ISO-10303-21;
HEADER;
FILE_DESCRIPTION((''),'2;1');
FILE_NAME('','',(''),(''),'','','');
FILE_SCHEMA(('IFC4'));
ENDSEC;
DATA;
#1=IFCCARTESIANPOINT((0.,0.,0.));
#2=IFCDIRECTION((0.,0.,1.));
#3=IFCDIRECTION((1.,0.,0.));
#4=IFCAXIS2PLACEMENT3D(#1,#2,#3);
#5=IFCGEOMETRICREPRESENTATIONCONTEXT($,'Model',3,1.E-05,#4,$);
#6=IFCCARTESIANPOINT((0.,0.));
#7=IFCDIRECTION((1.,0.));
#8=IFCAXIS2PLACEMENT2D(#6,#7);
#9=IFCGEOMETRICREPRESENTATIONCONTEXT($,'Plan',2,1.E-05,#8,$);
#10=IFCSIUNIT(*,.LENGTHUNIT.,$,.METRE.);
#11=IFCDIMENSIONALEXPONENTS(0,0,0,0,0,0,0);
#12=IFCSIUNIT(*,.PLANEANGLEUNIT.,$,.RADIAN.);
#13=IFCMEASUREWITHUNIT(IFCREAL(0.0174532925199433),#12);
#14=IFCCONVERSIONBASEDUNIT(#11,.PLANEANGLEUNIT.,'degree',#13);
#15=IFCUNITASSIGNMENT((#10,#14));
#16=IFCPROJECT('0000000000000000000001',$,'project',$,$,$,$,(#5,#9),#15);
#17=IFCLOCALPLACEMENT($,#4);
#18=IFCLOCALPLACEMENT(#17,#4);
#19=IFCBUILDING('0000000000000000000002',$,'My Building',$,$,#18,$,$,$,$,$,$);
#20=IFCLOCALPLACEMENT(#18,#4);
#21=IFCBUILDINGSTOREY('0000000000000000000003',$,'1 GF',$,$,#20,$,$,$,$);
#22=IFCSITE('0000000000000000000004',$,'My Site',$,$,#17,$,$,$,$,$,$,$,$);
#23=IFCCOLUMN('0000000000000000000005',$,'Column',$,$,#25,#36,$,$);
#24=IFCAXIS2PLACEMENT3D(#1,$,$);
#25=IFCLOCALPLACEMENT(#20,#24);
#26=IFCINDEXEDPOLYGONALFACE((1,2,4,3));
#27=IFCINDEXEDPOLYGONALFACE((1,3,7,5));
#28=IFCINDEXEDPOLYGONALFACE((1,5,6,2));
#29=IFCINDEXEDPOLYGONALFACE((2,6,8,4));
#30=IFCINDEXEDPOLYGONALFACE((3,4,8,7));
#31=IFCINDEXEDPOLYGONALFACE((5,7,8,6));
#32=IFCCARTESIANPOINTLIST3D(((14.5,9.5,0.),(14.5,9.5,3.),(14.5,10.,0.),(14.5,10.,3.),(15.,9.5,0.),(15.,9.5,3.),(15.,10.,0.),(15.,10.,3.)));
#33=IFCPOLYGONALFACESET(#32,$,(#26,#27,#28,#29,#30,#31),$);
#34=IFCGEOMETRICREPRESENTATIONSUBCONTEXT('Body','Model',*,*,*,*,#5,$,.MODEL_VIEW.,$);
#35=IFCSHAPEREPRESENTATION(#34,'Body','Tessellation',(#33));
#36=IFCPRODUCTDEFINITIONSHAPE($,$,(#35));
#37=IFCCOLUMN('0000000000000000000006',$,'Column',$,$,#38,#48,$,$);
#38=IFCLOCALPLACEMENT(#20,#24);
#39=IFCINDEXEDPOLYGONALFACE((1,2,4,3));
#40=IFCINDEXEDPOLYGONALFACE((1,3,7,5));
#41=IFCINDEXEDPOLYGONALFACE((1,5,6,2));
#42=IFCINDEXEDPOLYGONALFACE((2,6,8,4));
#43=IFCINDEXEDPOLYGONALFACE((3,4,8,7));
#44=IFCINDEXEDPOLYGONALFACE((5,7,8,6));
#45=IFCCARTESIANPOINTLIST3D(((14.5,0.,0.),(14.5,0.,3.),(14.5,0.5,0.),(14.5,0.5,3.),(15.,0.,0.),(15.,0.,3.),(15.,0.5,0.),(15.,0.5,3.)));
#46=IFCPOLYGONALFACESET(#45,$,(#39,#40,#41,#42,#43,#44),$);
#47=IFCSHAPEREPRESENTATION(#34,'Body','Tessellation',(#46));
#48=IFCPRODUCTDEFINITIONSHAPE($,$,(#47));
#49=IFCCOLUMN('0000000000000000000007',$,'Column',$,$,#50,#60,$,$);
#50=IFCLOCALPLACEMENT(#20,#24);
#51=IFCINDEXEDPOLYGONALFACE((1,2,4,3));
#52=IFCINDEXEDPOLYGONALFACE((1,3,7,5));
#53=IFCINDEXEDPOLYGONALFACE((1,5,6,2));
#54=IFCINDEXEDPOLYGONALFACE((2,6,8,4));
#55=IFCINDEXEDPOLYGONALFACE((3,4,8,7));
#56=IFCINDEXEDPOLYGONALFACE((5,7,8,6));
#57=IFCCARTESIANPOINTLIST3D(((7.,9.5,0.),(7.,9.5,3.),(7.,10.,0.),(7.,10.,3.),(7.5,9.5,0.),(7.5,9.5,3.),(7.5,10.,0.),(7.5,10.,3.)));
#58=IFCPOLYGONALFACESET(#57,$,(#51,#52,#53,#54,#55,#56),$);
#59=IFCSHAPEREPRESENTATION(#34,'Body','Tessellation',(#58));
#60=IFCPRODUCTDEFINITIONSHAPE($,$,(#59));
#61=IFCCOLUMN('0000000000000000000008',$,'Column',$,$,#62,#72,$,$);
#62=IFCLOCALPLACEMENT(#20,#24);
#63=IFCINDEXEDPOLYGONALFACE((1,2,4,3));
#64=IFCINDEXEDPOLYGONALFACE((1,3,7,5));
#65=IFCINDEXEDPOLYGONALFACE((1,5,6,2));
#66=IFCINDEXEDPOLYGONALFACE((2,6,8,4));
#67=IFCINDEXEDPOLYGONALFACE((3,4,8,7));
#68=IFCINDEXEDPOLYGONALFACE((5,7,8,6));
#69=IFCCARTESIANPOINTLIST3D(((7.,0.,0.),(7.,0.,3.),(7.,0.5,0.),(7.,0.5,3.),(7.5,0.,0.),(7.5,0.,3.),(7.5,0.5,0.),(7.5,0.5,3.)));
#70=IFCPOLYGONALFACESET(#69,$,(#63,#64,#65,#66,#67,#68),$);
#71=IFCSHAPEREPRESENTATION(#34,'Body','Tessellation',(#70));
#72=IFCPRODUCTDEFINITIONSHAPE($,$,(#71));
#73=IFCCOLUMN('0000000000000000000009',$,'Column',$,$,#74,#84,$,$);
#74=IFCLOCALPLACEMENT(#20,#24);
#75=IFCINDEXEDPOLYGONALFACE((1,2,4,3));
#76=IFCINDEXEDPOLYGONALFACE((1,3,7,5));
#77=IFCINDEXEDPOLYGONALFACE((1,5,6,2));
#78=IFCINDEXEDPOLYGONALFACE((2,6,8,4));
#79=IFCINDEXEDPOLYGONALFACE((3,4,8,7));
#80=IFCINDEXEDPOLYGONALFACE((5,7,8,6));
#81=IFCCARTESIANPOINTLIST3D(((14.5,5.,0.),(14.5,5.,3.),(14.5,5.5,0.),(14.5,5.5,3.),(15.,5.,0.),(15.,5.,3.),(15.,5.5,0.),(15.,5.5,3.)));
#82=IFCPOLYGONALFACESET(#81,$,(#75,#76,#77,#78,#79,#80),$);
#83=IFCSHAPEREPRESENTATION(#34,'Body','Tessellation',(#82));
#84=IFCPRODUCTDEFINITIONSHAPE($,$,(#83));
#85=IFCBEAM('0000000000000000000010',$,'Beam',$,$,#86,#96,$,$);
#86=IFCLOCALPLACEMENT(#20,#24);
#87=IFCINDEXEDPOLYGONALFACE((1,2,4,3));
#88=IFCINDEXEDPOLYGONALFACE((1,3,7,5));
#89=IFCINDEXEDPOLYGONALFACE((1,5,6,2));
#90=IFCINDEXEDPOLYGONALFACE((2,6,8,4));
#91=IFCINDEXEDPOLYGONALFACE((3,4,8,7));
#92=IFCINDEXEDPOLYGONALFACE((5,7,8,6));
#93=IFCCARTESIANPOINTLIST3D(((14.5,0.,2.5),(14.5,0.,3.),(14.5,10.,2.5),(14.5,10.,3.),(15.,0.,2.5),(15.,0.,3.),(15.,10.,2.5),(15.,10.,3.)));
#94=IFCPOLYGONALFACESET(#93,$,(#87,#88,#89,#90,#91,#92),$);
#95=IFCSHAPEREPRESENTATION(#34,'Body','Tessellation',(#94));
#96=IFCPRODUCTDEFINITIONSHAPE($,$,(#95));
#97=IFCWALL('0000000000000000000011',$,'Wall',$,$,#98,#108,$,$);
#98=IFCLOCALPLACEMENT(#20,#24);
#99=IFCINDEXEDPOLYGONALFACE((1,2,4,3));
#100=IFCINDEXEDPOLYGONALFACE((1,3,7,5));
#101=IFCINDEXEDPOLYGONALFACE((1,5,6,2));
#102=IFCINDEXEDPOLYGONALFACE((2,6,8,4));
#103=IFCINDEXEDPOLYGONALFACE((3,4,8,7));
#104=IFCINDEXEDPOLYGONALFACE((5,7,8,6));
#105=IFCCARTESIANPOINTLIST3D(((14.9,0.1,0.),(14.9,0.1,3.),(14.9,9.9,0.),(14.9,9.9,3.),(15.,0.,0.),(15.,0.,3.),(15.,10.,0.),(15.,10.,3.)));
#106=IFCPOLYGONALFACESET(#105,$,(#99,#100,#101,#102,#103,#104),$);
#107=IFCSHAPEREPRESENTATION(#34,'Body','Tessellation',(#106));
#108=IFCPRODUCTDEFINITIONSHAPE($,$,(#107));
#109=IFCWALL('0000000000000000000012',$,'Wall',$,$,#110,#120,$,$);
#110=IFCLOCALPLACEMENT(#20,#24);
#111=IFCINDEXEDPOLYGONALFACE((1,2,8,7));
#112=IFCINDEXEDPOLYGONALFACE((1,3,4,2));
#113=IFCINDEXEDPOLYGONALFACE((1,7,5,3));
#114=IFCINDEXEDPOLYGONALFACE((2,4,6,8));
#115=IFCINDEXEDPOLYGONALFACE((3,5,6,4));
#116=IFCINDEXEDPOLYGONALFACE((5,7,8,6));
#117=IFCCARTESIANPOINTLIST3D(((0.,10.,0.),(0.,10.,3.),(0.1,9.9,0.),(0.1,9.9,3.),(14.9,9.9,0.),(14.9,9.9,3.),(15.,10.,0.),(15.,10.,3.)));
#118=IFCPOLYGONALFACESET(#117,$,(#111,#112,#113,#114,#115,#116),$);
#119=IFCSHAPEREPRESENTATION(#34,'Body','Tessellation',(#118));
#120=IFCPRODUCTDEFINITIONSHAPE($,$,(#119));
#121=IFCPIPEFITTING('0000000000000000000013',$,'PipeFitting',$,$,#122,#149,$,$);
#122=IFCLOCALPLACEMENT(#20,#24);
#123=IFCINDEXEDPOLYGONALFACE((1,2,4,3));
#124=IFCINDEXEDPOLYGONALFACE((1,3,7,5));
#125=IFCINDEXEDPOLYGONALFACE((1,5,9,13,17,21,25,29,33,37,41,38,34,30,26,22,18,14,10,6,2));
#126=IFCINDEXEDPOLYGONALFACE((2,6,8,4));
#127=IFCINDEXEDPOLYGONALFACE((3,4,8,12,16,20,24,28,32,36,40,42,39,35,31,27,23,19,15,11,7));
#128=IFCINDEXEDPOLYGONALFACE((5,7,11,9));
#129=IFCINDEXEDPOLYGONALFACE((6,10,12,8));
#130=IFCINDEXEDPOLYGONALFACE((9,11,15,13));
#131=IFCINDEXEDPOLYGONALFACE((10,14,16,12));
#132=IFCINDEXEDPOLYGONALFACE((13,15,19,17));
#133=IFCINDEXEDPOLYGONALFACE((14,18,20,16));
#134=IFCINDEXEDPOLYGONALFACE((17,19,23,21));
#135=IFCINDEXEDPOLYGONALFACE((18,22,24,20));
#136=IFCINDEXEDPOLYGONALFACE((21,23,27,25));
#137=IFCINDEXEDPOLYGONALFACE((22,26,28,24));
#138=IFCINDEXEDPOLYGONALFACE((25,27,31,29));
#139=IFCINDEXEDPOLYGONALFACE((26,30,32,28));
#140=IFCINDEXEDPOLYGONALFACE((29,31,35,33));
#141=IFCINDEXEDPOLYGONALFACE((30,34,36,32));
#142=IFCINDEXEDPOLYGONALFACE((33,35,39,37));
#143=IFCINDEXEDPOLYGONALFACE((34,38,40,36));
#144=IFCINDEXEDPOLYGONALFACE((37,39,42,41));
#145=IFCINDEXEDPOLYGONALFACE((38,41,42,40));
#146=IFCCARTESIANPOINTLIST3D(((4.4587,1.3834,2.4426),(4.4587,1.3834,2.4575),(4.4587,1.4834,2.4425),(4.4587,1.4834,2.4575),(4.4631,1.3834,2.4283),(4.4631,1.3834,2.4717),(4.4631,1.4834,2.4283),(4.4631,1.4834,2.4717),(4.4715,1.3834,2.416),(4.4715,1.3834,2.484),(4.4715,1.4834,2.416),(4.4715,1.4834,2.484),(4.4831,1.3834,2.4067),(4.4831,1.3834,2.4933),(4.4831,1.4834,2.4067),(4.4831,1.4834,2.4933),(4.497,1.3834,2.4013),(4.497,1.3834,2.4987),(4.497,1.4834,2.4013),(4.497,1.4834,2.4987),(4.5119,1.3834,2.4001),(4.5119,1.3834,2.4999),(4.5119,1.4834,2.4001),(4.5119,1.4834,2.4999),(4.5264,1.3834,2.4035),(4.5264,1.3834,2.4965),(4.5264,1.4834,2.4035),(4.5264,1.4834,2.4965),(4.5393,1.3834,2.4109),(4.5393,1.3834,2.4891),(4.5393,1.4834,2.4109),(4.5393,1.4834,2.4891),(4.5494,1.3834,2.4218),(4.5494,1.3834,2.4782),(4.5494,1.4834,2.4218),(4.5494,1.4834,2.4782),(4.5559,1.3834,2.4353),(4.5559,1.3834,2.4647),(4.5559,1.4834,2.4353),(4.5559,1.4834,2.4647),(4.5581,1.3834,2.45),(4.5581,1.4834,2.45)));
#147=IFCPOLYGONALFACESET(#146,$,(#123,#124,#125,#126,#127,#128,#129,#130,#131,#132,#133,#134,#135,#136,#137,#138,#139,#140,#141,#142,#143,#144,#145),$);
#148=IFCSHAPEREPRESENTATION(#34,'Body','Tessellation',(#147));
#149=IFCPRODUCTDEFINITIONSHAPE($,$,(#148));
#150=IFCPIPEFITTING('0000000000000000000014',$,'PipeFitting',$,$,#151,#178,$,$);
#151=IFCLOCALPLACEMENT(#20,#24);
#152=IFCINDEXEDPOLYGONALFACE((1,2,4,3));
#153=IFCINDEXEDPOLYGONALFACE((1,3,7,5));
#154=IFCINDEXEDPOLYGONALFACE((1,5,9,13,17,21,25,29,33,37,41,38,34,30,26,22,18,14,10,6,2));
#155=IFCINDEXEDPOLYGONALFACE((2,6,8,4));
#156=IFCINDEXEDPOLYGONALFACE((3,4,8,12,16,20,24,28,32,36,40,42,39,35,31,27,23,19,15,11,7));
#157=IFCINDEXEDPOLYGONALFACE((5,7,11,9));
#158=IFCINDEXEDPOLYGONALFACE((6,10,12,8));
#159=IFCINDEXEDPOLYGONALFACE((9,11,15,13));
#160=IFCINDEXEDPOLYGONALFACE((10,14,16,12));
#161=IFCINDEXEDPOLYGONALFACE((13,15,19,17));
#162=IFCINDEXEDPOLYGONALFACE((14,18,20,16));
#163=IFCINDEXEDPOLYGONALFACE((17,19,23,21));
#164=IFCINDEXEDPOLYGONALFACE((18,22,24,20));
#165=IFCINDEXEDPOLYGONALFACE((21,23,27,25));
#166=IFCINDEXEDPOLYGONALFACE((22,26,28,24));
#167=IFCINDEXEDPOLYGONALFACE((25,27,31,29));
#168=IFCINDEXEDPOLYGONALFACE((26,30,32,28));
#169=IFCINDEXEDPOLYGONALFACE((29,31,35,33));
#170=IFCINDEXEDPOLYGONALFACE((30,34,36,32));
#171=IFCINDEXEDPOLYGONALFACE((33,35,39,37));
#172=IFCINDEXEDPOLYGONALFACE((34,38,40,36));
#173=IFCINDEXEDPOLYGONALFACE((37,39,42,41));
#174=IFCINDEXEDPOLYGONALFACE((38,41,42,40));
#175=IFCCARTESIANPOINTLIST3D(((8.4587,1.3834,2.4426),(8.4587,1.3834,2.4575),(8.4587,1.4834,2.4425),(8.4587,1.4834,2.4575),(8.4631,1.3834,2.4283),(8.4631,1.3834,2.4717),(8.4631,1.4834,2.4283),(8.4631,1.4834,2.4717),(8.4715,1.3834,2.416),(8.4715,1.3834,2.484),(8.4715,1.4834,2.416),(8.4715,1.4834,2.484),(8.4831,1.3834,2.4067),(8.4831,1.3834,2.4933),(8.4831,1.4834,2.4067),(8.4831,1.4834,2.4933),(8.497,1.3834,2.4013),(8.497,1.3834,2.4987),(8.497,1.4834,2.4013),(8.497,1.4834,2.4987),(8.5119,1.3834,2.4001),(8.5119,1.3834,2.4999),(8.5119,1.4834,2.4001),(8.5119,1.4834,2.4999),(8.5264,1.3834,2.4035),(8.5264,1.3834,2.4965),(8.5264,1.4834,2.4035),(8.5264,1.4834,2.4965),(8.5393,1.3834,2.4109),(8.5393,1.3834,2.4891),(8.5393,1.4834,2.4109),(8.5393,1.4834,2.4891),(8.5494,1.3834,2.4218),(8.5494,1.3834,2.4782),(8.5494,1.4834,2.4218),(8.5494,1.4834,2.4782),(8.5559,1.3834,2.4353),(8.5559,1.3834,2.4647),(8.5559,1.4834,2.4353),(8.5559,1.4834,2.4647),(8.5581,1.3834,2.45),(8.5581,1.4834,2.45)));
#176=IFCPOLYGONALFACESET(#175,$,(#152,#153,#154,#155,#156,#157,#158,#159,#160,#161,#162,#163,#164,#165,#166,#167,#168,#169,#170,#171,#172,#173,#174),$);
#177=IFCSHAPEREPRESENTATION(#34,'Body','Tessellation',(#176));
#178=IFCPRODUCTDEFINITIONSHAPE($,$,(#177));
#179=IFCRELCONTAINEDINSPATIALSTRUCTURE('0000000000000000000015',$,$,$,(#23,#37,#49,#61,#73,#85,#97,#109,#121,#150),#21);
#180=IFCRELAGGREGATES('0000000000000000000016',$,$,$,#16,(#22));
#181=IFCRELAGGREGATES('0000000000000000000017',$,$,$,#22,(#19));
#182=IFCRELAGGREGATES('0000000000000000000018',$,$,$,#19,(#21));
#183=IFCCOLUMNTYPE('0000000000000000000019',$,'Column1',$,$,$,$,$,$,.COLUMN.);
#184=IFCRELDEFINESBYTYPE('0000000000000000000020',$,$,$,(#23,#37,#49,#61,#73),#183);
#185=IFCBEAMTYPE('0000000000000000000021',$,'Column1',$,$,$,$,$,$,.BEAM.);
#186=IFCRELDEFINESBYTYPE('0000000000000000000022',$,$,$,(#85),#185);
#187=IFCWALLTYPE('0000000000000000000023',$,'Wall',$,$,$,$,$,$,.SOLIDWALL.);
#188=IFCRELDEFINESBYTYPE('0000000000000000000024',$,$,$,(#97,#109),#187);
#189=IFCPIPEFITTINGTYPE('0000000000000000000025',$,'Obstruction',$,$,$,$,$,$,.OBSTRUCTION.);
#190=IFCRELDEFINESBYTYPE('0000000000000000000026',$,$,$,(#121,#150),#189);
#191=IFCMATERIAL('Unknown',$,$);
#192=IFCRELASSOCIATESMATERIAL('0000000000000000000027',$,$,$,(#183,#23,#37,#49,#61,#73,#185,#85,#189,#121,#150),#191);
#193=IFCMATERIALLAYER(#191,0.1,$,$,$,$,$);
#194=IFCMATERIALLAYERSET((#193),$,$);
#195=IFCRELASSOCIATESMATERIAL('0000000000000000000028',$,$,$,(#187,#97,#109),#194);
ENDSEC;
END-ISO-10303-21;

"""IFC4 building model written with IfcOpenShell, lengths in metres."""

from ifc_helpers import new_model, entity, si_unit, converted_unit, frame, origin_with_axes, origin_2d_with_axis, place, context, subcontext, project, spatial, line, indexed_curve, rectangle, circle, outline, extrude, material, layer, layer_set, layer_usage, material_profile, profile_set, profile_usage, type_object, element, save


model = new_model("IFC4")

# Units and contexts
model_context = context("Model", 3, precision=1e-05, world=origin_with_axes())
plan_context = context("Plan", 2, precision=1e-05, world=origin_2d_with_axis())
body_context = subcontext(model_context, "Body", "Model", "MODEL_VIEW")
ifc_project = project(units=[si_unit("LENGTHUNIT", "METRE"), converted_unit("PLANEANGLEUNIT", "degree", entity("IfcReal", 0.0174532925199433), si_unit("PLANEANGLEUNIT", "RADIAN"), dimensions=[0, 0, 0, 0, 0, 0, 0])], contexts=[model_context, plan_context])

# Site, building, storey
site_placement = place(None, origin_with_axes())
site = spatial("IfcSite", under=ifc_project, at=site_placement, Name="My Site")
building_placement = place(site_placement, origin_with_axes())
building = spatial("IfcBuilding", under=site, at=building_placement, Name="My Building")
storey_placement = place(building_placement, origin_with_axes())
storey = spatial("IfcBuildingStorey", under=building, at=storey_placement, Name="1 GF")

# Columns
ifc_material = material(Name="Unknown")
ifc_material_profile_1 = material_profile(ifc_material, rectangle(XDim=0.5, YDim=0.5))
ifc_profile_set_1 = profile_set([ifc_material_profile_1])
ifc_profile_usage_1 = profile_usage(ifc_profile_set_1, cardinal=1)
column_type = type_object("IfcColumnType", Name="Column1", PredefinedType="COLUMN", material=ifc_profile_set_1)
column_1_placement = place(storey_placement, frame((15.0, 9.5, 0.0), z_axis=(0.0, 0.0, 1.0), x_axis=(1.0, 0.0, 0.0)))
element("IfcColumn", 1, at=column_1_placement, inside=storey, type_object=column_type, material=ifc_profile_usage_1, Name="Column", context=body_context, shape_type="SweptSolid", body=[
    extrude(rectangle(XDim=0.5, YDim=0.5), frame((-0.25, 0.25, 0.0), z_axis=(0.0, 0.0, 1.0), x_axis=(1.0, 0.0, 0.0)), (0.0, 0.0, 1.0), 3.0),
])
ifc_profile_usage_2 = profile_usage(ifc_profile_set_1, cardinal=1)
column_2_placement = place(storey_placement, frame((15.0, 0.0, 0.0), z_axis=(0.0, 0.0, 1.0), x_axis=(1.0, 0.0, 0.0)))
element("IfcColumn", 2, at=column_2_placement, inside=storey, type_object=column_type, material=ifc_profile_usage_2, Name="Column", context=body_context, shape_type="SweptSolid", body=[
    extrude(rectangle(XDim=0.5, YDim=0.5), frame((-0.25, 0.25, 0.0), z_axis=(0.0, 0.0, 1.0), x_axis=(1.0, 0.0, 0.0)), (0.0, 0.0, 1.0), 3.0),
])
ifc_profile_usage_3 = profile_usage(ifc_profile_set_1, cardinal=1)
column_3_placement = place(storey_placement, frame((7.5, 9.5, 0.0), z_axis=(0.0, 0.0, 1.0), x_axis=(1.0, 0.0, 0.0)))
element("IfcColumn", 3, at=column_3_placement, inside=storey, type_object=column_type, material=ifc_profile_usage_3, Name="Column", context=body_context, shape_type="SweptSolid", body=[
    extrude(rectangle(XDim=0.5, YDim=0.5), frame((-0.25, 0.25, 0.0), z_axis=(0.0, 0.0, 1.0), x_axis=(1.0, 0.0, 0.0)), (0.0, 0.0, 1.0), 3.0),
])
ifc_profile_usage_4 = profile_usage(ifc_profile_set_1, cardinal=1)
column_4_placement = place(storey_placement, frame((7.5, 0.0, 0.0), z_axis=(0.0, 0.0, 1.0), x_axis=(1.0, 0.0, 0.0)))
element("IfcColumn", 4, at=column_4_placement, inside=storey, type_object=column_type, material=ifc_profile_usage_4, Name="Column", context=body_context, shape_type="SweptSolid", body=[
    extrude(rectangle(XDim=0.5, YDim=0.5), frame((-0.25, 0.25, 0.0), z_axis=(0.0, 0.0, 1.0), x_axis=(1.0, 0.0, 0.0)), (0.0, 0.0, 1.0), 3.0),
])
ifc_profile_usage_5 = profile_usage(ifc_profile_set_1, cardinal=1)
column_5_placement = place(storey_placement, frame((15.0, 5.0, 0.0), z_axis=(0.0, 0.0, 1.0), x_axis=(1.0, 0.0, 0.0)))
element("IfcColumn", 5, at=column_5_placement, inside=storey, type_object=column_type, material=ifc_profile_usage_5, Name="Column", context=body_context, shape_type="SweptSolid", body=[
    extrude(rectangle(XDim=0.5, YDim=0.5), frame((-0.25, 0.25, 0.0), z_axis=(0.0, 0.0, 1.0), x_axis=(1.0, 0.0, 0.0)), (0.0, 0.0, 1.0), 3.0),
])

# Beam
ifc_material_profile_2 = material_profile(ifc_material, rectangle(XDim=0.5, YDim=0.5))
ifc_profile_set_2 = profile_set([ifc_material_profile_2])
ifc_profile_usage_6 = profile_usage(ifc_profile_set_2, cardinal=7)
beam_type = type_object("IfcBeamType", Name="Column1", PredefinedType="BEAM", material=ifc_profile_set_2)
beam_placement = place(storey_placement, frame((15.0, 10.0, 3.0), z_axis=(0.0, -1.0, 0.0), x_axis=(1.0, 0.0, 0.0)))
element("IfcBeam", 6, at=beam_placement, inside=storey, type_object=beam_type, material=ifc_profile_usage_6, Name="Beam", context=body_context, shape_type="SweptSolid", body=[
    extrude(rectangle(XDim=0.5, YDim=0.5), frame((-0.25, -0.25, 0.0), z_axis=(0.0, 0.0, 1.0), x_axis=(1.0, 0.0, 0.0)), (0.0, 0.0, 1.0), 10.0),
])

# Walls
ifc_layer = layer(ifc_material, 0.1)
ifc_layer_set = layer_set([ifc_layer])
ifc_layer_usage_1 = layer_usage(ifc_layer_set, "AXIS2", "POSITIVE", 0.0)
wall_type = type_object("IfcWallType", Name="Wall", PredefinedType="SOLIDWALL", material=ifc_layer_set)
wall_1_placement = place(storey_placement, frame((15.0, 0.0, 0.0), z_axis=(0.0, 0.0, 1.0), x_axis=(0.0, 1.0, 0.0)))
element("IfcWall", 7, at=wall_1_placement, inside=storey, type_object=wall_type, material=ifc_layer_usage_1, Name="Wall", context=body_context, shape_type="SweptSolid", body=[
    extrude(outline(indexed_curve([(0.0, 0.0), (0.1, 0.1), (9.9, 0.1), (10.0, 0.0)], segments=[line(1, 2, 3, 4, 1)])), origin_with_axes(), (0.0, 0.0, 1.0), 3.0),
])
ifc_layer_usage_2 = layer_usage(ifc_layer_set, "AXIS2", "POSITIVE", 0.0)
wall_2_placement = place(storey_placement, frame((15.0, 10.0, 0.0), z_axis=(0.0, 0.0, 1.0), x_axis=(-1.0, 0.0, 0.0)))
element("IfcWall", 8, at=wall_2_placement, inside=storey, type_object=wall_type, material=ifc_layer_usage_2, Name="Wall", context=body_context, shape_type="SweptSolid", body=[
    extrude(outline(indexed_curve([(0.0, 0.0), (0.1, 0.1), (14.9, 0.1), (15.0, 0.0)], segments=[line(1, 2, 3, 4, 1)])), origin_with_axes(), (0.0, 0.0, 1.0), 3.0),
])

# Pipe fittings
ifc_material_profile_3 = material_profile(ifc_material, circle(Radius=0.05))
ifc_profile_set_3 = profile_set([ifc_material_profile_3])
ifc_profile_usage_7 = profile_usage(ifc_profile_set_3, cardinal=5)
pipe_fitting_type = type_object("IfcPipeFittingType", Name="Obstruction", PredefinedType="OBSTRUCTION", material=ifc_profile_set_3)
pipe_fitting_1_placement = place(storey_placement, frame((4.5081, 1.4834, 2.45), z_axis=(0.0, -1.0, 0.000025), x_axis=(1.0, 0.0, 0.0)))
element("IfcPipeFitting", 9, at=pipe_fitting_1_placement, inside=storey, type_object=pipe_fitting_type, material=ifc_profile_usage_7, Name="PipeFitting", context=body_context, shape_type="SweptSolid", body=[
    extrude(circle(Radius=0.05), origin_with_axes(), (0.0, 0.0, 1.0), 0.1),
])
ifc_profile_usage_8 = profile_usage(ifc_profile_set_3, cardinal=5)
pipe_fitting_2_placement = place(storey_placement, frame((8.5081, 1.4834, 2.45), z_axis=(0.0, -1.0, 0.000025), x_axis=(1.0, 0.0, 0.0)))
element("IfcPipeFitting", 10, at=pipe_fitting_2_placement, inside=storey, type_object=pipe_fitting_type, material=ifc_profile_usage_8, Name="PipeFitting", context=body_context, shape_type="SweptSolid", body=[
    extrude(circle(Radius=0.05), origin_with_axes(), (0.0, 0.0, 1.0), 0.1),
])

save(model, "model.ifc")
